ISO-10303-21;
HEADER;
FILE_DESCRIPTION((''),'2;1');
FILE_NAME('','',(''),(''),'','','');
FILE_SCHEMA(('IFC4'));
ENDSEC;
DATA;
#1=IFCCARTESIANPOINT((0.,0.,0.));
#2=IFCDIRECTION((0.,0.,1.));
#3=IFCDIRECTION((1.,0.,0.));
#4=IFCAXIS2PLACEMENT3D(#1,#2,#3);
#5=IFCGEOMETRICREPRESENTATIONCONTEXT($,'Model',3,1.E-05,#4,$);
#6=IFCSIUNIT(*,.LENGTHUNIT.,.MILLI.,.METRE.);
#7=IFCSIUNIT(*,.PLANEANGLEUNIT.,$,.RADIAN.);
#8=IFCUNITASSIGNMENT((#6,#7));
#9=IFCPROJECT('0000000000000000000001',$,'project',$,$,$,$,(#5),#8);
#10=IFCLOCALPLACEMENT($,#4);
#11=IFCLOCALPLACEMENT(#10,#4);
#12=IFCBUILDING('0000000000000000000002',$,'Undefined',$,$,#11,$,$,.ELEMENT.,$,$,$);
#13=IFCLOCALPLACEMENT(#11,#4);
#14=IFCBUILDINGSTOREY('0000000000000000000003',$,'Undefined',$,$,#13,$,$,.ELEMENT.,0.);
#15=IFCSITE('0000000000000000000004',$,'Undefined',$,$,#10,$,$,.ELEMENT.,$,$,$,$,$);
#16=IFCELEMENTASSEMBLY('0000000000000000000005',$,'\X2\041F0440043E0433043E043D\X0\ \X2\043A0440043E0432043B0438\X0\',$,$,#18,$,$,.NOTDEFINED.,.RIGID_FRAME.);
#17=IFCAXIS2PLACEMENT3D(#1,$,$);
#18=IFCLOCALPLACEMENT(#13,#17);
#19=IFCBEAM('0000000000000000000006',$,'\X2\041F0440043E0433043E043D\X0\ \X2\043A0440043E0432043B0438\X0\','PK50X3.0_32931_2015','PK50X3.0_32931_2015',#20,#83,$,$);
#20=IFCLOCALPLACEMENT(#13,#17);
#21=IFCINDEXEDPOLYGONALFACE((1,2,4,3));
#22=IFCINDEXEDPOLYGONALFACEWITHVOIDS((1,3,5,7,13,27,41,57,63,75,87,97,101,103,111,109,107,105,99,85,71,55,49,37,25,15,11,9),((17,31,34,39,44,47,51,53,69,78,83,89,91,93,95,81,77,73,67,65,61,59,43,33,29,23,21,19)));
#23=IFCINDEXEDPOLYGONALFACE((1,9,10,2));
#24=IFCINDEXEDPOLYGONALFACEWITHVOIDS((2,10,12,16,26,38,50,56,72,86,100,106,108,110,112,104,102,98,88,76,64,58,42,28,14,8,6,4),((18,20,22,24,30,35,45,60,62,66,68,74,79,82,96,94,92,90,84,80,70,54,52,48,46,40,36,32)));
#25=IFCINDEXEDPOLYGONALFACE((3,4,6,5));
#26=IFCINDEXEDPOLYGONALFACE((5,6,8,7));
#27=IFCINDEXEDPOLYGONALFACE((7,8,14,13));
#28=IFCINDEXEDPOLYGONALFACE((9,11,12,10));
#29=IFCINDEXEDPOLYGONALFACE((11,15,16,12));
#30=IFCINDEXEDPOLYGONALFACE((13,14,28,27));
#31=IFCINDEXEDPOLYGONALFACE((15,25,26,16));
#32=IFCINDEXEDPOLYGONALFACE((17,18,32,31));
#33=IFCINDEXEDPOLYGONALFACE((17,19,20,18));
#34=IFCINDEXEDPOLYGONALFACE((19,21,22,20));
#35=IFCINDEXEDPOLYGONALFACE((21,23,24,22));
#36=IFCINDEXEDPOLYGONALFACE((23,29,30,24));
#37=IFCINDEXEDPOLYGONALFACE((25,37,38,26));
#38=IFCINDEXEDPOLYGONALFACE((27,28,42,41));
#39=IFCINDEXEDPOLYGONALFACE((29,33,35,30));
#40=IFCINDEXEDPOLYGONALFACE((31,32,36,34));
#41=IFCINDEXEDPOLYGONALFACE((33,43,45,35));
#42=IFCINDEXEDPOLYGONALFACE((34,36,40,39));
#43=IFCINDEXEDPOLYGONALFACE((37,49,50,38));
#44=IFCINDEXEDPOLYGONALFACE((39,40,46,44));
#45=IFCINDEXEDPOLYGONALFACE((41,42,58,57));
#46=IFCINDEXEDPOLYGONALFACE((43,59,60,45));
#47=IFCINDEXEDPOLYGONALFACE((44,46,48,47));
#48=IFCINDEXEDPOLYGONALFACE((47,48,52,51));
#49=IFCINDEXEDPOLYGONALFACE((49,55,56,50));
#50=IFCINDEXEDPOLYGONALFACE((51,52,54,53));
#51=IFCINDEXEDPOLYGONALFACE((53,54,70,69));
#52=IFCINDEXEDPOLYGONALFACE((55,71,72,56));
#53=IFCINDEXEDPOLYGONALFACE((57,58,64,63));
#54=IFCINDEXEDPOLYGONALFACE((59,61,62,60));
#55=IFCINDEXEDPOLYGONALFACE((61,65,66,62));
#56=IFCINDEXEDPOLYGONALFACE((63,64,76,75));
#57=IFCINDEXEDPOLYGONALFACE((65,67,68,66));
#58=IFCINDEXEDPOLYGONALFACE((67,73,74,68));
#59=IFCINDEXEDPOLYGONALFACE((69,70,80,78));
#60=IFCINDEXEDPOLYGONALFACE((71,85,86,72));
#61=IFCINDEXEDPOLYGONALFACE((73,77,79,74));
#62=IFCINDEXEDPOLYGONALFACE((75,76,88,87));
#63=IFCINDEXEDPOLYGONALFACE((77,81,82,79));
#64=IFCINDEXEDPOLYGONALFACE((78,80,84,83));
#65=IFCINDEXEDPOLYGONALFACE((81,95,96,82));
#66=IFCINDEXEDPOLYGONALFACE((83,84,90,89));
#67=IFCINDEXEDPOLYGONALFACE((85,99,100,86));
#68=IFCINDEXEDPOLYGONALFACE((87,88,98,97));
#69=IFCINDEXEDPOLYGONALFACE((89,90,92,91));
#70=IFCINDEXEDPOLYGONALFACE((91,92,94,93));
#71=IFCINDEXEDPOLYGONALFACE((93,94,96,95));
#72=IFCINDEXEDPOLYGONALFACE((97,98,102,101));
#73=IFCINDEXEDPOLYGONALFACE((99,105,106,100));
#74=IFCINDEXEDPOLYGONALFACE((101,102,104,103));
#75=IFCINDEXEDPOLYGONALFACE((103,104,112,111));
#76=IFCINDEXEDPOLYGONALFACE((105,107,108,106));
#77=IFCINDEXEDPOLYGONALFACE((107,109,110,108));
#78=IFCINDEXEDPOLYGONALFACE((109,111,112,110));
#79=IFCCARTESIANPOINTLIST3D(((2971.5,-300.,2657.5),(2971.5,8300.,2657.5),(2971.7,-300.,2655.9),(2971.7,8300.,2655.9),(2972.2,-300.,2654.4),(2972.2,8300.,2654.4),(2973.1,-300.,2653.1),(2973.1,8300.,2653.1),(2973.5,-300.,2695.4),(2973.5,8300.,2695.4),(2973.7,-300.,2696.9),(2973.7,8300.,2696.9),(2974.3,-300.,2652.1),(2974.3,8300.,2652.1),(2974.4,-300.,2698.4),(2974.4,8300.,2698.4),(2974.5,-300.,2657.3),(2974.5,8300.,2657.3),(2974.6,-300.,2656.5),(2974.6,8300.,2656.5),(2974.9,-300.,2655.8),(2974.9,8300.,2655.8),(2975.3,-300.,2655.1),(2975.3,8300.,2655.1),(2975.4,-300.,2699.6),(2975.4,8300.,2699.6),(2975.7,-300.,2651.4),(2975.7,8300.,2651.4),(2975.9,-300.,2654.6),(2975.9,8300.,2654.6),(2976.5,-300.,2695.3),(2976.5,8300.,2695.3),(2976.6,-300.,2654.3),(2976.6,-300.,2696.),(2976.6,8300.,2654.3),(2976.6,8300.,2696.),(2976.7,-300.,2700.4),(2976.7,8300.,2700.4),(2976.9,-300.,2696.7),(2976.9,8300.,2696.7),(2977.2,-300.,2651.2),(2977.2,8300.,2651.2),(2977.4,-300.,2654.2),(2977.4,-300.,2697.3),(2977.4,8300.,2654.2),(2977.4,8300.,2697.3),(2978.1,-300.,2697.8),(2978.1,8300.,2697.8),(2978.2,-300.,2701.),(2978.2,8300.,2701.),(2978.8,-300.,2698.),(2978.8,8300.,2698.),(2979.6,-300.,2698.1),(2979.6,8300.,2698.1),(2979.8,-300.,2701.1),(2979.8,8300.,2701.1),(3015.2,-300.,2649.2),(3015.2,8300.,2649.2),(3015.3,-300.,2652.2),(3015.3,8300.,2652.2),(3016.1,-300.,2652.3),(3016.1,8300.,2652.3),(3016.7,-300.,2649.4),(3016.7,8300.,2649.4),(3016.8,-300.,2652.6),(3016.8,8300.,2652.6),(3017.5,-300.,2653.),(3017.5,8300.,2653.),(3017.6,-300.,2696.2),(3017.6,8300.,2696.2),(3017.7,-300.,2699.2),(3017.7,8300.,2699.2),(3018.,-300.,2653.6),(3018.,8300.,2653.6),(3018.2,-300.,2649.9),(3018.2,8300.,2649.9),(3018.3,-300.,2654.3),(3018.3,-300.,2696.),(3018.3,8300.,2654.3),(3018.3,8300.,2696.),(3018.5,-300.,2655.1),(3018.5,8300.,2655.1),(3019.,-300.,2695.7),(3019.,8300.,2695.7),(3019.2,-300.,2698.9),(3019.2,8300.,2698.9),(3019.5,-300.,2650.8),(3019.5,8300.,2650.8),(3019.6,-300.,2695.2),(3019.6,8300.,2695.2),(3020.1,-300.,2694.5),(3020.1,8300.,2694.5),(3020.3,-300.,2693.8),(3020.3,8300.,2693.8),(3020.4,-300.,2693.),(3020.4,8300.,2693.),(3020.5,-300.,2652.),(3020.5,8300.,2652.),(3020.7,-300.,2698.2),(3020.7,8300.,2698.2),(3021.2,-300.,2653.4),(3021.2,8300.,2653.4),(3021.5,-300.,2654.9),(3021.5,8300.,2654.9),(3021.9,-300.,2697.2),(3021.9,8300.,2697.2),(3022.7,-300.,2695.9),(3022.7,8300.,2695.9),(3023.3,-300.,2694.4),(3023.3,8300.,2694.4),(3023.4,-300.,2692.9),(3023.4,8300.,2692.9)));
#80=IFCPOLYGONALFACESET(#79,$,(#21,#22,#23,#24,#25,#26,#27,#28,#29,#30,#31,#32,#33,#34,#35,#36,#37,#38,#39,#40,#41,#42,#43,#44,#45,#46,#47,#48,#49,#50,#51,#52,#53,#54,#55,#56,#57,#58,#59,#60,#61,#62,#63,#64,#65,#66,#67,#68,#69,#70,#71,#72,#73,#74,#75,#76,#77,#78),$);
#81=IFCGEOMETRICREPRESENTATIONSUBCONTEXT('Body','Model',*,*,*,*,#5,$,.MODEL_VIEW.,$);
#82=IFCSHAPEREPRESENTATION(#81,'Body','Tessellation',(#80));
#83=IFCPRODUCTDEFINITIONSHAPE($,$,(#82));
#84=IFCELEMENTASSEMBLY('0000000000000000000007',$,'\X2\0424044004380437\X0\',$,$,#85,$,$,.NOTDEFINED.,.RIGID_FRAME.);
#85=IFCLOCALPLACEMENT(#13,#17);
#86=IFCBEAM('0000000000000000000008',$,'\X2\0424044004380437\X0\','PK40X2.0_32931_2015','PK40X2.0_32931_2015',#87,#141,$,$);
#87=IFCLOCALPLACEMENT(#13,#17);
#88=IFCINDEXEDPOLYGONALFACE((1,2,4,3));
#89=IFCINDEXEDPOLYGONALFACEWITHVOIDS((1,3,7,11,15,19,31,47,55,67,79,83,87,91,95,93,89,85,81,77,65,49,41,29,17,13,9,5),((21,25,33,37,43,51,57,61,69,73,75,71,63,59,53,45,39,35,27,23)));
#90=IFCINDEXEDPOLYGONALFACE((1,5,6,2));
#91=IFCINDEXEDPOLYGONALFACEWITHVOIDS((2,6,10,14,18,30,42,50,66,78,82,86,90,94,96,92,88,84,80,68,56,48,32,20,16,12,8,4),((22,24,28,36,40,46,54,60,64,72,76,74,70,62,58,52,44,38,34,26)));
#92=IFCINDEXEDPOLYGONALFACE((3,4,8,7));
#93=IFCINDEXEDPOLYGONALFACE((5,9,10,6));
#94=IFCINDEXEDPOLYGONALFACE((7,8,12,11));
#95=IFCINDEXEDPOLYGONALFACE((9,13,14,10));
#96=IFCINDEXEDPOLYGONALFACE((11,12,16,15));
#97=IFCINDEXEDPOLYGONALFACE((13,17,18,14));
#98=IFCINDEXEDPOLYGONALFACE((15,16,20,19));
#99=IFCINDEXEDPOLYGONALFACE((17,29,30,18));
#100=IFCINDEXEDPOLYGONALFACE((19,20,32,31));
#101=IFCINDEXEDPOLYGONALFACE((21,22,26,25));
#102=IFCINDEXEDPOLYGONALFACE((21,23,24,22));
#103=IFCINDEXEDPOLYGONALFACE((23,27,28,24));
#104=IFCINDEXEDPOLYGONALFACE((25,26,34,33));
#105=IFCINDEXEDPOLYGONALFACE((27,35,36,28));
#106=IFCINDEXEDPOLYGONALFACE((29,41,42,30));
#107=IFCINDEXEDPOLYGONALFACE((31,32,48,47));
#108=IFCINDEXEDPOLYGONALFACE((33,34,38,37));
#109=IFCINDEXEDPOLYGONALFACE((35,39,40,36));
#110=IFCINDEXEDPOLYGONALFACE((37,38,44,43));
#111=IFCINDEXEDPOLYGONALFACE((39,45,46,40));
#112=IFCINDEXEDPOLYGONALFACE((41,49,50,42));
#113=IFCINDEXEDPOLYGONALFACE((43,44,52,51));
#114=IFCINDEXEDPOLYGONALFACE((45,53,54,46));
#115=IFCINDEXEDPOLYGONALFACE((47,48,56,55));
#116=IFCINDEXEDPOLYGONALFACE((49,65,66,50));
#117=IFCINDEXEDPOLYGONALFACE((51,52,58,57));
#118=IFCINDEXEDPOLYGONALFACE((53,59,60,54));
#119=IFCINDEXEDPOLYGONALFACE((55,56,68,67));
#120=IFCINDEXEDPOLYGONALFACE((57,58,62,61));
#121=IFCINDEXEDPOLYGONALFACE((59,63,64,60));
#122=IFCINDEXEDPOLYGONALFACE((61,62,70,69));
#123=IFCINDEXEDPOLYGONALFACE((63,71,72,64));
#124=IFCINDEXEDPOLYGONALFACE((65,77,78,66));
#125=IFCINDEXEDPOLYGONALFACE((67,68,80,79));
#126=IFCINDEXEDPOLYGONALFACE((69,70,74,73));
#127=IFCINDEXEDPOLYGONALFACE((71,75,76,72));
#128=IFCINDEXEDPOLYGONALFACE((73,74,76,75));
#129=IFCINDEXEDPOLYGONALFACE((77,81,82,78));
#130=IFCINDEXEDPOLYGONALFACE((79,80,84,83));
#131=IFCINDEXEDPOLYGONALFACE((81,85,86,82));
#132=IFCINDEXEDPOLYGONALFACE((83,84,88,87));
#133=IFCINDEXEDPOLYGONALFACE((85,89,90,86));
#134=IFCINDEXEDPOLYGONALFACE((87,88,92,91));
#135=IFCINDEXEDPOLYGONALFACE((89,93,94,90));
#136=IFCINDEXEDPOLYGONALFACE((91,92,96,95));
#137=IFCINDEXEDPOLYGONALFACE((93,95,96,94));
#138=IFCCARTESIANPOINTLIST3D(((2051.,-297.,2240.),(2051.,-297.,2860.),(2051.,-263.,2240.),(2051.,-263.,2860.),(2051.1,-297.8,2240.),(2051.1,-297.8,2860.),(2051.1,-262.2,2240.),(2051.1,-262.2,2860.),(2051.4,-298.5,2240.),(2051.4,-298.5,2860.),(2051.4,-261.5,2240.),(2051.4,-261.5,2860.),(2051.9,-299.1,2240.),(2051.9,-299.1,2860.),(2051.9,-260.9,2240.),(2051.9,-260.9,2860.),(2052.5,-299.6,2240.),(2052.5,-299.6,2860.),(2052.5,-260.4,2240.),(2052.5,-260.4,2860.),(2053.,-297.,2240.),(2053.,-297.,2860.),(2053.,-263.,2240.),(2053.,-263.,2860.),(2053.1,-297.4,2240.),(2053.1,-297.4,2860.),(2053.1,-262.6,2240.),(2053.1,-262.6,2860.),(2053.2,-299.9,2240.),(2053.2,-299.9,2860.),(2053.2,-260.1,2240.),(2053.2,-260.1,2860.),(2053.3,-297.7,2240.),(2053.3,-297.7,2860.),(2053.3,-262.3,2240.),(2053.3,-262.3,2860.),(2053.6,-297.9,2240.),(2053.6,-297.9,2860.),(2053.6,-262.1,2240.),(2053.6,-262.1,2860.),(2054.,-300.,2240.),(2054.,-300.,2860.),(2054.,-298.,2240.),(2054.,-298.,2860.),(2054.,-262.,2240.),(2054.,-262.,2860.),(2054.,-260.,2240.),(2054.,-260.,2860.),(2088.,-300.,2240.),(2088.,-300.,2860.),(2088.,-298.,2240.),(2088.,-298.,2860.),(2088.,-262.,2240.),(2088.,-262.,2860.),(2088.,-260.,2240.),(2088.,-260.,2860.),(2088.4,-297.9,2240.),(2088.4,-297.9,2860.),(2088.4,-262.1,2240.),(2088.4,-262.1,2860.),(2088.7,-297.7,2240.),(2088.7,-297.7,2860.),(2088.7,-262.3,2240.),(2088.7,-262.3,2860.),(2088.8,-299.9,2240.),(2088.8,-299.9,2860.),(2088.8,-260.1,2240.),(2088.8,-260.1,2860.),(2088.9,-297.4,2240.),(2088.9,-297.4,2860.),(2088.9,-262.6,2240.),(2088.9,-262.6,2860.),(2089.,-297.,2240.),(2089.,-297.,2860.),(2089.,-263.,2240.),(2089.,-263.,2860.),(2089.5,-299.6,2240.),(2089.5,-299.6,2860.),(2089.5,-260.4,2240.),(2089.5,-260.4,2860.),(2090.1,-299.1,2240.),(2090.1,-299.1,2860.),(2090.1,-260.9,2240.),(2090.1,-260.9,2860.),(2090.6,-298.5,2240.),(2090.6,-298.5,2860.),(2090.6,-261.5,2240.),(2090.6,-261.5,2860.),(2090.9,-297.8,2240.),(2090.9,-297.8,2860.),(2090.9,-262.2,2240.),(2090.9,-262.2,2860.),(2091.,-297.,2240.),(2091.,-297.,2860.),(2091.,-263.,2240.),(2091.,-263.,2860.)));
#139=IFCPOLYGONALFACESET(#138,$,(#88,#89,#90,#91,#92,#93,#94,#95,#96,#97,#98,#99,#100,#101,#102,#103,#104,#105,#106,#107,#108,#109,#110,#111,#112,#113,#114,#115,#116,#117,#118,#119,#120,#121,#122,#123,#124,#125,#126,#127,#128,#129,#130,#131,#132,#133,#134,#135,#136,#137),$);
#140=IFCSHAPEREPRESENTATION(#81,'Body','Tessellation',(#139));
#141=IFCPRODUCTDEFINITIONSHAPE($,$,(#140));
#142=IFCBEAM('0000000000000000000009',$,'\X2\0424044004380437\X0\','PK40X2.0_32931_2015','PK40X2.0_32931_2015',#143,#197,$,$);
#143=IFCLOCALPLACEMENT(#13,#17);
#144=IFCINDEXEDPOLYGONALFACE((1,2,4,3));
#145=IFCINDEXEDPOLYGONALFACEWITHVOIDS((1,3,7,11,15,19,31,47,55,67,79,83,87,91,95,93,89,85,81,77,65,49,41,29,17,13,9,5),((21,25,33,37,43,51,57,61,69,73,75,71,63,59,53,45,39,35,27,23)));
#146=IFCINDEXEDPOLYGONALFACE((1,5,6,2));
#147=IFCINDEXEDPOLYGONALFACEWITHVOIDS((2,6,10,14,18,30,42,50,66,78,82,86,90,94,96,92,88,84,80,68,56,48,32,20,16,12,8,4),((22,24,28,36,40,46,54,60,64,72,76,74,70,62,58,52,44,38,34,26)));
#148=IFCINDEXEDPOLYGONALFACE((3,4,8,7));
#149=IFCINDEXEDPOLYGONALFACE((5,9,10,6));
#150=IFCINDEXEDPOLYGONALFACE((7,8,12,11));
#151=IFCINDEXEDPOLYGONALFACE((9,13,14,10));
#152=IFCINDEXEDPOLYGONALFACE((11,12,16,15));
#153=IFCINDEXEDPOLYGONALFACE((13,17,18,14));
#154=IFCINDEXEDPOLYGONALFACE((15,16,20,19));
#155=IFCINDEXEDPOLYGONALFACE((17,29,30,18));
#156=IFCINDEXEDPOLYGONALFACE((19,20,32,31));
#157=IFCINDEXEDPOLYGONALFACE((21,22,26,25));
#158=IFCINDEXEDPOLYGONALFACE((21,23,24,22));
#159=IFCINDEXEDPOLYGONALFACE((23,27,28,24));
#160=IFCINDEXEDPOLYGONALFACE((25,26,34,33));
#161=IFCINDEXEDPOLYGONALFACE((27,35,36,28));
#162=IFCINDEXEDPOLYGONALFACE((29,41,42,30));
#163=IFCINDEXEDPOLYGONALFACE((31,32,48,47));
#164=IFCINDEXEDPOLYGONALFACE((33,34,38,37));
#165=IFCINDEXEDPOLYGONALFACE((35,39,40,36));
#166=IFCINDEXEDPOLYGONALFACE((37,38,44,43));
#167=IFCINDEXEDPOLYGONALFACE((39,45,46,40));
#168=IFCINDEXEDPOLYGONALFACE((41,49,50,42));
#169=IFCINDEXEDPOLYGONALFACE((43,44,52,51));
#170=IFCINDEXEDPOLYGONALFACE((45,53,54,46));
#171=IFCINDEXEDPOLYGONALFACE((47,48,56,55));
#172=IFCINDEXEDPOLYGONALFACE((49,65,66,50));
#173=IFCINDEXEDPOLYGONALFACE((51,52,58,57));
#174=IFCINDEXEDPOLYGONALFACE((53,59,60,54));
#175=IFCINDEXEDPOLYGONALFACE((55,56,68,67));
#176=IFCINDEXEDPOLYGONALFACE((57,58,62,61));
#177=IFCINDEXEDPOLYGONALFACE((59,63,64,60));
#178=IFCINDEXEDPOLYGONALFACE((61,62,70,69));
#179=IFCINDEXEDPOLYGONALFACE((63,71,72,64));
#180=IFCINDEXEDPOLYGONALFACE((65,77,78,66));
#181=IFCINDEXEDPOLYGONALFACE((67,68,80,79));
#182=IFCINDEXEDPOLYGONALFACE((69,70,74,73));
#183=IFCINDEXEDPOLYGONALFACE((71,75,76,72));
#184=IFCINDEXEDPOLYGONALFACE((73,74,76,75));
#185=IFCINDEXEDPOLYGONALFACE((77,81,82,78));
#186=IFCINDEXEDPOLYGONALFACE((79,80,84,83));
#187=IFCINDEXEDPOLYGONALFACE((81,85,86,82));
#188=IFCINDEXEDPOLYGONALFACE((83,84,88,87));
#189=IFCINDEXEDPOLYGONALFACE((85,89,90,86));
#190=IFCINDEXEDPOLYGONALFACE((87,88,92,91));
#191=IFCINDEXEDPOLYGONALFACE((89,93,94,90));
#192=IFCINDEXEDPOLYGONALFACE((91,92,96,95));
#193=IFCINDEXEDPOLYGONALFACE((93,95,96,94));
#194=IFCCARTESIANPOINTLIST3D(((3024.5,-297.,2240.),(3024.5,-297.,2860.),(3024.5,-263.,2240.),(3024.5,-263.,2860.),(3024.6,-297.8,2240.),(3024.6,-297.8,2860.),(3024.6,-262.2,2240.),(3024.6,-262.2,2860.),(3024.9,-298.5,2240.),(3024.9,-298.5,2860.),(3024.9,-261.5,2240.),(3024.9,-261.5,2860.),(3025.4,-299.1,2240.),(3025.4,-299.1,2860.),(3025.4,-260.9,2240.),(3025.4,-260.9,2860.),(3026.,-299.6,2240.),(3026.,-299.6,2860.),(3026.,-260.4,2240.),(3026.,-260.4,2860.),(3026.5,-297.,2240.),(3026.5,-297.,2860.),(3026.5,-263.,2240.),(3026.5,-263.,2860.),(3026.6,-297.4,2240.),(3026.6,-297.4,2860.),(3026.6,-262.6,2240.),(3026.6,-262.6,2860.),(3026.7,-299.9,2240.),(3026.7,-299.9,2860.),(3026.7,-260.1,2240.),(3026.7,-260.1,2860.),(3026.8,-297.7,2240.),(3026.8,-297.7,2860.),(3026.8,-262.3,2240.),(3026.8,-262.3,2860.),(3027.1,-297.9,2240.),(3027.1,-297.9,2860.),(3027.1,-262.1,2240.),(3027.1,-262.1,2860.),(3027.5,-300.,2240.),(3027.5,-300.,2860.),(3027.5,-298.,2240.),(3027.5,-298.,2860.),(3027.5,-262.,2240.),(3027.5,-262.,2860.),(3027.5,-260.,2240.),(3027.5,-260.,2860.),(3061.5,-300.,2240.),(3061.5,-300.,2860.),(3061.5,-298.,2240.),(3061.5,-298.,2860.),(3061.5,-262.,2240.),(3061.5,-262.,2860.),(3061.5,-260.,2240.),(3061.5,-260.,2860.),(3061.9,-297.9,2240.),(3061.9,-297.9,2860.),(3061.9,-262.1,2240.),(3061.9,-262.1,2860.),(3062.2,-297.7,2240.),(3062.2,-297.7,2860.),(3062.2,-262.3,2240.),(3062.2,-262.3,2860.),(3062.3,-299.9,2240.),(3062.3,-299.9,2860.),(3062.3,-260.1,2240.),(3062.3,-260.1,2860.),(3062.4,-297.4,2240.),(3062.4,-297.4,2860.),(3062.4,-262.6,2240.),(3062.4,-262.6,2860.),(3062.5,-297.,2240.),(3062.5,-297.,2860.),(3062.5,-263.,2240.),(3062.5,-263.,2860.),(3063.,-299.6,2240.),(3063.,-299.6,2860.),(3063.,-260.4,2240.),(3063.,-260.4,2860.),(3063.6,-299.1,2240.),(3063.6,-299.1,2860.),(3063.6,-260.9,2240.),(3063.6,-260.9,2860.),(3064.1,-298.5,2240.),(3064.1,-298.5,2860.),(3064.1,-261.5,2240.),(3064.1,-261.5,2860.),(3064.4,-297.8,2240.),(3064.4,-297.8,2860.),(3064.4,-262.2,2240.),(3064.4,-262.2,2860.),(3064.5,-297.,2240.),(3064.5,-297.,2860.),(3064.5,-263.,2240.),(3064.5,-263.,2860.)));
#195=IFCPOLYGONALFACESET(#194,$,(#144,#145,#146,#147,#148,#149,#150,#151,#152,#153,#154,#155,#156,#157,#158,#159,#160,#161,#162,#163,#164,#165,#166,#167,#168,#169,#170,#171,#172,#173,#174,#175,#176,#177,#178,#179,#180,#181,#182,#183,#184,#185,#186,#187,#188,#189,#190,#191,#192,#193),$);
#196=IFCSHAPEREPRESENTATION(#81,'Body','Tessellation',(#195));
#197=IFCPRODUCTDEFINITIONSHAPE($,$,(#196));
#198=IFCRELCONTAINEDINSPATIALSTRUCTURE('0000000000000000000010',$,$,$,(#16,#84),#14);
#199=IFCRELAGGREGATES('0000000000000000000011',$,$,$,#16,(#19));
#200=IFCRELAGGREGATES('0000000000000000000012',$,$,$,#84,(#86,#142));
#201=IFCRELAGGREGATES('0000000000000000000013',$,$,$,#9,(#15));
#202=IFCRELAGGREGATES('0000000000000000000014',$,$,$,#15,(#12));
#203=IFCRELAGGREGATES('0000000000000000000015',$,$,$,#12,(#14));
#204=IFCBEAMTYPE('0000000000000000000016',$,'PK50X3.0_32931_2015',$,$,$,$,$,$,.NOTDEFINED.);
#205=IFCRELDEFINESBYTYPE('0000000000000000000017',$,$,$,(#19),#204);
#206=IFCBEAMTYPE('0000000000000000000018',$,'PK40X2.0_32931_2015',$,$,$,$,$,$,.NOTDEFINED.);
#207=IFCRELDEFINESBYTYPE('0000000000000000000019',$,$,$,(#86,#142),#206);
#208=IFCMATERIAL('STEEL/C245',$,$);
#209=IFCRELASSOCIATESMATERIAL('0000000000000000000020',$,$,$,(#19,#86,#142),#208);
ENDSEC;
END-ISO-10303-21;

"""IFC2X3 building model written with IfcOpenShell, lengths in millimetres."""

from ifc_helpers import new_model, si_unit, frame, origin_with_axes, origin_2d_with_axis, place, context, subcontext, project, spatial, hollow_rectangle, extrude, material, type_object, element, aggregate, save


model = new_model("IFC2X3")

# Units and contexts
model_context = context("Model", 3, precision=1e-05, world=origin_with_axes())
body_context = subcontext(model_context, "Body", "Model", "MODEL_VIEW")
ifc_project = project(units=[si_unit("LENGTHUNIT", "METRE", prefix="MILLI"), si_unit("PLANEANGLEUNIT", "RADIAN")], contexts=[model_context])

# Site, building, storey
site_placement = place(None, origin_with_axes())
site = spatial("IfcSite", under=ifc_project, at=site_placement, Name="Undefined", CompositionType="ELEMENT")
building_placement = place(site_placement, origin_with_axes())
building = spatial("IfcBuilding", under=site, at=building_placement, Name="Undefined", CompositionType="ELEMENT")
storey_placement = place(building_placement, origin_with_axes())
storey = spatial("IfcBuildingStorey", under=building, at=storey_placement, Name="Undefined", CompositionType="ELEMENT", Elevation=0.0)

# Shared definitions
ifc_material_1 = material(Name="STEEL/C245")

# Element assembly, beam
beam_type_1 = type_object("IfcBeamType", Name="PK50X3.0_32931_2015", PredefinedType="NOTDEFINED")
assembly_1_placement = place(storey_placement, origin_with_axes())
assembly_1 = element("IfcElementAssembly", 1, at=assembly_1_placement, inside=storey, Name="Прогон кровли", AssemblyPlace="NOTDEFINED", PredefinedType="RIGID_FRAME")
beam_1_placement = place(assembly_1_placement, frame((2997.5, -300.0, 2675.2), z_axis=(0.050782, 0.0, 0.99871), x_axis=(0.0, 1.0, 0.0)))
beam_1 = element("IfcBeam", 2, at=beam_1_placement, type_object=beam_type_1, material=ifc_material_1, Name="Прогон кровли", Description="PK50X3.0_32931_2015", ObjectType="PK50X3.0_32931_2015", context=body_context, shape_type="SweptSolid", body=[
    extrude(hollow_rectangle(XDim=50.0, YDim=50.0, WallThickness=3.0, InnerFilletRadius=3.0, OuterFilletRadius=6.0, at=origin_2d_with_axis()), frame((8600.0, 0.0, 0.0), z_axis=(-1.0, 0.0, 0.0), x_axis=(0.0, -1.0, 0.0)), (0.0, 0.0, 1.0), 8600.0),
])
aggregate(assembly_1, [beam_1])

# Element assembly, beams
assembly_2_placement = place(storey_placement, origin_with_axes())
assembly_2 = element("IfcElementAssembly", 3, at=assembly_2_placement, inside=storey, Name="Фриз", AssemblyPlace="NOTDEFINED", PredefinedType="RIGID_FRAME")
beam_type_2 = type_object("IfcBeamType", Name="PK40X2.0_32931_2015", PredefinedType="NOTDEFINED")
beam_2_placement = place(assembly_2_placement, frame((2071.0, -280.0, 2860.0), z_axis=(1.0, 0.0, 0.0), x_axis=(0.0, 0.0, -1.0)))
beam_2 = element("IfcBeam", 4, at=beam_2_placement, type_object=beam_type_2, material=ifc_material_1, Name="Фриз", Description="PK40X2.0_32931_2015", ObjectType="PK40X2.0_32931_2015", context=body_context, shape_type="SweptSolid", body=[
    extrude(hollow_rectangle(XDim=40.0, YDim=40.0, WallThickness=2.0, InnerFilletRadius=1.0, OuterFilletRadius=3.0, at=origin_2d_with_axis()), frame((620.0, 0.0, 0.0), z_axis=(-1.0, 0.0, 0.0), x_axis=(0.0, -1.0, 0.0)), (0.0, 0.0, 1.0), 620.0),
])
beam_3_placement = place(assembly_2_placement, frame((3044.5, -280.0, 2860.0), z_axis=(1.0, 0.0, 0.0), x_axis=(0.0, 0.0, -1.0)))
beam_3 = element("IfcBeam", 5, at=beam_3_placement, type_object=beam_type_2, material=ifc_material_1, Name="Фриз", Description="PK40X2.0_32931_2015", ObjectType="PK40X2.0_32931_2015", context=body_context, shape_type="SweptSolid", body=[
    extrude(hollow_rectangle(XDim=40.0, YDim=40.0, WallThickness=2.0, InnerFilletRadius=1.0, OuterFilletRadius=3.0, at=origin_2d_with_axis()), frame((620.0, 0.0, 0.0), z_axis=(-1.0, 0.0, 0.0), x_axis=(0.0, -1.0, 0.0)), (0.0, 0.0, 1.0), 620.0),
])
aggregate(assembly_2, [beam_2, beam_3])

save(model, "model.ifc")
